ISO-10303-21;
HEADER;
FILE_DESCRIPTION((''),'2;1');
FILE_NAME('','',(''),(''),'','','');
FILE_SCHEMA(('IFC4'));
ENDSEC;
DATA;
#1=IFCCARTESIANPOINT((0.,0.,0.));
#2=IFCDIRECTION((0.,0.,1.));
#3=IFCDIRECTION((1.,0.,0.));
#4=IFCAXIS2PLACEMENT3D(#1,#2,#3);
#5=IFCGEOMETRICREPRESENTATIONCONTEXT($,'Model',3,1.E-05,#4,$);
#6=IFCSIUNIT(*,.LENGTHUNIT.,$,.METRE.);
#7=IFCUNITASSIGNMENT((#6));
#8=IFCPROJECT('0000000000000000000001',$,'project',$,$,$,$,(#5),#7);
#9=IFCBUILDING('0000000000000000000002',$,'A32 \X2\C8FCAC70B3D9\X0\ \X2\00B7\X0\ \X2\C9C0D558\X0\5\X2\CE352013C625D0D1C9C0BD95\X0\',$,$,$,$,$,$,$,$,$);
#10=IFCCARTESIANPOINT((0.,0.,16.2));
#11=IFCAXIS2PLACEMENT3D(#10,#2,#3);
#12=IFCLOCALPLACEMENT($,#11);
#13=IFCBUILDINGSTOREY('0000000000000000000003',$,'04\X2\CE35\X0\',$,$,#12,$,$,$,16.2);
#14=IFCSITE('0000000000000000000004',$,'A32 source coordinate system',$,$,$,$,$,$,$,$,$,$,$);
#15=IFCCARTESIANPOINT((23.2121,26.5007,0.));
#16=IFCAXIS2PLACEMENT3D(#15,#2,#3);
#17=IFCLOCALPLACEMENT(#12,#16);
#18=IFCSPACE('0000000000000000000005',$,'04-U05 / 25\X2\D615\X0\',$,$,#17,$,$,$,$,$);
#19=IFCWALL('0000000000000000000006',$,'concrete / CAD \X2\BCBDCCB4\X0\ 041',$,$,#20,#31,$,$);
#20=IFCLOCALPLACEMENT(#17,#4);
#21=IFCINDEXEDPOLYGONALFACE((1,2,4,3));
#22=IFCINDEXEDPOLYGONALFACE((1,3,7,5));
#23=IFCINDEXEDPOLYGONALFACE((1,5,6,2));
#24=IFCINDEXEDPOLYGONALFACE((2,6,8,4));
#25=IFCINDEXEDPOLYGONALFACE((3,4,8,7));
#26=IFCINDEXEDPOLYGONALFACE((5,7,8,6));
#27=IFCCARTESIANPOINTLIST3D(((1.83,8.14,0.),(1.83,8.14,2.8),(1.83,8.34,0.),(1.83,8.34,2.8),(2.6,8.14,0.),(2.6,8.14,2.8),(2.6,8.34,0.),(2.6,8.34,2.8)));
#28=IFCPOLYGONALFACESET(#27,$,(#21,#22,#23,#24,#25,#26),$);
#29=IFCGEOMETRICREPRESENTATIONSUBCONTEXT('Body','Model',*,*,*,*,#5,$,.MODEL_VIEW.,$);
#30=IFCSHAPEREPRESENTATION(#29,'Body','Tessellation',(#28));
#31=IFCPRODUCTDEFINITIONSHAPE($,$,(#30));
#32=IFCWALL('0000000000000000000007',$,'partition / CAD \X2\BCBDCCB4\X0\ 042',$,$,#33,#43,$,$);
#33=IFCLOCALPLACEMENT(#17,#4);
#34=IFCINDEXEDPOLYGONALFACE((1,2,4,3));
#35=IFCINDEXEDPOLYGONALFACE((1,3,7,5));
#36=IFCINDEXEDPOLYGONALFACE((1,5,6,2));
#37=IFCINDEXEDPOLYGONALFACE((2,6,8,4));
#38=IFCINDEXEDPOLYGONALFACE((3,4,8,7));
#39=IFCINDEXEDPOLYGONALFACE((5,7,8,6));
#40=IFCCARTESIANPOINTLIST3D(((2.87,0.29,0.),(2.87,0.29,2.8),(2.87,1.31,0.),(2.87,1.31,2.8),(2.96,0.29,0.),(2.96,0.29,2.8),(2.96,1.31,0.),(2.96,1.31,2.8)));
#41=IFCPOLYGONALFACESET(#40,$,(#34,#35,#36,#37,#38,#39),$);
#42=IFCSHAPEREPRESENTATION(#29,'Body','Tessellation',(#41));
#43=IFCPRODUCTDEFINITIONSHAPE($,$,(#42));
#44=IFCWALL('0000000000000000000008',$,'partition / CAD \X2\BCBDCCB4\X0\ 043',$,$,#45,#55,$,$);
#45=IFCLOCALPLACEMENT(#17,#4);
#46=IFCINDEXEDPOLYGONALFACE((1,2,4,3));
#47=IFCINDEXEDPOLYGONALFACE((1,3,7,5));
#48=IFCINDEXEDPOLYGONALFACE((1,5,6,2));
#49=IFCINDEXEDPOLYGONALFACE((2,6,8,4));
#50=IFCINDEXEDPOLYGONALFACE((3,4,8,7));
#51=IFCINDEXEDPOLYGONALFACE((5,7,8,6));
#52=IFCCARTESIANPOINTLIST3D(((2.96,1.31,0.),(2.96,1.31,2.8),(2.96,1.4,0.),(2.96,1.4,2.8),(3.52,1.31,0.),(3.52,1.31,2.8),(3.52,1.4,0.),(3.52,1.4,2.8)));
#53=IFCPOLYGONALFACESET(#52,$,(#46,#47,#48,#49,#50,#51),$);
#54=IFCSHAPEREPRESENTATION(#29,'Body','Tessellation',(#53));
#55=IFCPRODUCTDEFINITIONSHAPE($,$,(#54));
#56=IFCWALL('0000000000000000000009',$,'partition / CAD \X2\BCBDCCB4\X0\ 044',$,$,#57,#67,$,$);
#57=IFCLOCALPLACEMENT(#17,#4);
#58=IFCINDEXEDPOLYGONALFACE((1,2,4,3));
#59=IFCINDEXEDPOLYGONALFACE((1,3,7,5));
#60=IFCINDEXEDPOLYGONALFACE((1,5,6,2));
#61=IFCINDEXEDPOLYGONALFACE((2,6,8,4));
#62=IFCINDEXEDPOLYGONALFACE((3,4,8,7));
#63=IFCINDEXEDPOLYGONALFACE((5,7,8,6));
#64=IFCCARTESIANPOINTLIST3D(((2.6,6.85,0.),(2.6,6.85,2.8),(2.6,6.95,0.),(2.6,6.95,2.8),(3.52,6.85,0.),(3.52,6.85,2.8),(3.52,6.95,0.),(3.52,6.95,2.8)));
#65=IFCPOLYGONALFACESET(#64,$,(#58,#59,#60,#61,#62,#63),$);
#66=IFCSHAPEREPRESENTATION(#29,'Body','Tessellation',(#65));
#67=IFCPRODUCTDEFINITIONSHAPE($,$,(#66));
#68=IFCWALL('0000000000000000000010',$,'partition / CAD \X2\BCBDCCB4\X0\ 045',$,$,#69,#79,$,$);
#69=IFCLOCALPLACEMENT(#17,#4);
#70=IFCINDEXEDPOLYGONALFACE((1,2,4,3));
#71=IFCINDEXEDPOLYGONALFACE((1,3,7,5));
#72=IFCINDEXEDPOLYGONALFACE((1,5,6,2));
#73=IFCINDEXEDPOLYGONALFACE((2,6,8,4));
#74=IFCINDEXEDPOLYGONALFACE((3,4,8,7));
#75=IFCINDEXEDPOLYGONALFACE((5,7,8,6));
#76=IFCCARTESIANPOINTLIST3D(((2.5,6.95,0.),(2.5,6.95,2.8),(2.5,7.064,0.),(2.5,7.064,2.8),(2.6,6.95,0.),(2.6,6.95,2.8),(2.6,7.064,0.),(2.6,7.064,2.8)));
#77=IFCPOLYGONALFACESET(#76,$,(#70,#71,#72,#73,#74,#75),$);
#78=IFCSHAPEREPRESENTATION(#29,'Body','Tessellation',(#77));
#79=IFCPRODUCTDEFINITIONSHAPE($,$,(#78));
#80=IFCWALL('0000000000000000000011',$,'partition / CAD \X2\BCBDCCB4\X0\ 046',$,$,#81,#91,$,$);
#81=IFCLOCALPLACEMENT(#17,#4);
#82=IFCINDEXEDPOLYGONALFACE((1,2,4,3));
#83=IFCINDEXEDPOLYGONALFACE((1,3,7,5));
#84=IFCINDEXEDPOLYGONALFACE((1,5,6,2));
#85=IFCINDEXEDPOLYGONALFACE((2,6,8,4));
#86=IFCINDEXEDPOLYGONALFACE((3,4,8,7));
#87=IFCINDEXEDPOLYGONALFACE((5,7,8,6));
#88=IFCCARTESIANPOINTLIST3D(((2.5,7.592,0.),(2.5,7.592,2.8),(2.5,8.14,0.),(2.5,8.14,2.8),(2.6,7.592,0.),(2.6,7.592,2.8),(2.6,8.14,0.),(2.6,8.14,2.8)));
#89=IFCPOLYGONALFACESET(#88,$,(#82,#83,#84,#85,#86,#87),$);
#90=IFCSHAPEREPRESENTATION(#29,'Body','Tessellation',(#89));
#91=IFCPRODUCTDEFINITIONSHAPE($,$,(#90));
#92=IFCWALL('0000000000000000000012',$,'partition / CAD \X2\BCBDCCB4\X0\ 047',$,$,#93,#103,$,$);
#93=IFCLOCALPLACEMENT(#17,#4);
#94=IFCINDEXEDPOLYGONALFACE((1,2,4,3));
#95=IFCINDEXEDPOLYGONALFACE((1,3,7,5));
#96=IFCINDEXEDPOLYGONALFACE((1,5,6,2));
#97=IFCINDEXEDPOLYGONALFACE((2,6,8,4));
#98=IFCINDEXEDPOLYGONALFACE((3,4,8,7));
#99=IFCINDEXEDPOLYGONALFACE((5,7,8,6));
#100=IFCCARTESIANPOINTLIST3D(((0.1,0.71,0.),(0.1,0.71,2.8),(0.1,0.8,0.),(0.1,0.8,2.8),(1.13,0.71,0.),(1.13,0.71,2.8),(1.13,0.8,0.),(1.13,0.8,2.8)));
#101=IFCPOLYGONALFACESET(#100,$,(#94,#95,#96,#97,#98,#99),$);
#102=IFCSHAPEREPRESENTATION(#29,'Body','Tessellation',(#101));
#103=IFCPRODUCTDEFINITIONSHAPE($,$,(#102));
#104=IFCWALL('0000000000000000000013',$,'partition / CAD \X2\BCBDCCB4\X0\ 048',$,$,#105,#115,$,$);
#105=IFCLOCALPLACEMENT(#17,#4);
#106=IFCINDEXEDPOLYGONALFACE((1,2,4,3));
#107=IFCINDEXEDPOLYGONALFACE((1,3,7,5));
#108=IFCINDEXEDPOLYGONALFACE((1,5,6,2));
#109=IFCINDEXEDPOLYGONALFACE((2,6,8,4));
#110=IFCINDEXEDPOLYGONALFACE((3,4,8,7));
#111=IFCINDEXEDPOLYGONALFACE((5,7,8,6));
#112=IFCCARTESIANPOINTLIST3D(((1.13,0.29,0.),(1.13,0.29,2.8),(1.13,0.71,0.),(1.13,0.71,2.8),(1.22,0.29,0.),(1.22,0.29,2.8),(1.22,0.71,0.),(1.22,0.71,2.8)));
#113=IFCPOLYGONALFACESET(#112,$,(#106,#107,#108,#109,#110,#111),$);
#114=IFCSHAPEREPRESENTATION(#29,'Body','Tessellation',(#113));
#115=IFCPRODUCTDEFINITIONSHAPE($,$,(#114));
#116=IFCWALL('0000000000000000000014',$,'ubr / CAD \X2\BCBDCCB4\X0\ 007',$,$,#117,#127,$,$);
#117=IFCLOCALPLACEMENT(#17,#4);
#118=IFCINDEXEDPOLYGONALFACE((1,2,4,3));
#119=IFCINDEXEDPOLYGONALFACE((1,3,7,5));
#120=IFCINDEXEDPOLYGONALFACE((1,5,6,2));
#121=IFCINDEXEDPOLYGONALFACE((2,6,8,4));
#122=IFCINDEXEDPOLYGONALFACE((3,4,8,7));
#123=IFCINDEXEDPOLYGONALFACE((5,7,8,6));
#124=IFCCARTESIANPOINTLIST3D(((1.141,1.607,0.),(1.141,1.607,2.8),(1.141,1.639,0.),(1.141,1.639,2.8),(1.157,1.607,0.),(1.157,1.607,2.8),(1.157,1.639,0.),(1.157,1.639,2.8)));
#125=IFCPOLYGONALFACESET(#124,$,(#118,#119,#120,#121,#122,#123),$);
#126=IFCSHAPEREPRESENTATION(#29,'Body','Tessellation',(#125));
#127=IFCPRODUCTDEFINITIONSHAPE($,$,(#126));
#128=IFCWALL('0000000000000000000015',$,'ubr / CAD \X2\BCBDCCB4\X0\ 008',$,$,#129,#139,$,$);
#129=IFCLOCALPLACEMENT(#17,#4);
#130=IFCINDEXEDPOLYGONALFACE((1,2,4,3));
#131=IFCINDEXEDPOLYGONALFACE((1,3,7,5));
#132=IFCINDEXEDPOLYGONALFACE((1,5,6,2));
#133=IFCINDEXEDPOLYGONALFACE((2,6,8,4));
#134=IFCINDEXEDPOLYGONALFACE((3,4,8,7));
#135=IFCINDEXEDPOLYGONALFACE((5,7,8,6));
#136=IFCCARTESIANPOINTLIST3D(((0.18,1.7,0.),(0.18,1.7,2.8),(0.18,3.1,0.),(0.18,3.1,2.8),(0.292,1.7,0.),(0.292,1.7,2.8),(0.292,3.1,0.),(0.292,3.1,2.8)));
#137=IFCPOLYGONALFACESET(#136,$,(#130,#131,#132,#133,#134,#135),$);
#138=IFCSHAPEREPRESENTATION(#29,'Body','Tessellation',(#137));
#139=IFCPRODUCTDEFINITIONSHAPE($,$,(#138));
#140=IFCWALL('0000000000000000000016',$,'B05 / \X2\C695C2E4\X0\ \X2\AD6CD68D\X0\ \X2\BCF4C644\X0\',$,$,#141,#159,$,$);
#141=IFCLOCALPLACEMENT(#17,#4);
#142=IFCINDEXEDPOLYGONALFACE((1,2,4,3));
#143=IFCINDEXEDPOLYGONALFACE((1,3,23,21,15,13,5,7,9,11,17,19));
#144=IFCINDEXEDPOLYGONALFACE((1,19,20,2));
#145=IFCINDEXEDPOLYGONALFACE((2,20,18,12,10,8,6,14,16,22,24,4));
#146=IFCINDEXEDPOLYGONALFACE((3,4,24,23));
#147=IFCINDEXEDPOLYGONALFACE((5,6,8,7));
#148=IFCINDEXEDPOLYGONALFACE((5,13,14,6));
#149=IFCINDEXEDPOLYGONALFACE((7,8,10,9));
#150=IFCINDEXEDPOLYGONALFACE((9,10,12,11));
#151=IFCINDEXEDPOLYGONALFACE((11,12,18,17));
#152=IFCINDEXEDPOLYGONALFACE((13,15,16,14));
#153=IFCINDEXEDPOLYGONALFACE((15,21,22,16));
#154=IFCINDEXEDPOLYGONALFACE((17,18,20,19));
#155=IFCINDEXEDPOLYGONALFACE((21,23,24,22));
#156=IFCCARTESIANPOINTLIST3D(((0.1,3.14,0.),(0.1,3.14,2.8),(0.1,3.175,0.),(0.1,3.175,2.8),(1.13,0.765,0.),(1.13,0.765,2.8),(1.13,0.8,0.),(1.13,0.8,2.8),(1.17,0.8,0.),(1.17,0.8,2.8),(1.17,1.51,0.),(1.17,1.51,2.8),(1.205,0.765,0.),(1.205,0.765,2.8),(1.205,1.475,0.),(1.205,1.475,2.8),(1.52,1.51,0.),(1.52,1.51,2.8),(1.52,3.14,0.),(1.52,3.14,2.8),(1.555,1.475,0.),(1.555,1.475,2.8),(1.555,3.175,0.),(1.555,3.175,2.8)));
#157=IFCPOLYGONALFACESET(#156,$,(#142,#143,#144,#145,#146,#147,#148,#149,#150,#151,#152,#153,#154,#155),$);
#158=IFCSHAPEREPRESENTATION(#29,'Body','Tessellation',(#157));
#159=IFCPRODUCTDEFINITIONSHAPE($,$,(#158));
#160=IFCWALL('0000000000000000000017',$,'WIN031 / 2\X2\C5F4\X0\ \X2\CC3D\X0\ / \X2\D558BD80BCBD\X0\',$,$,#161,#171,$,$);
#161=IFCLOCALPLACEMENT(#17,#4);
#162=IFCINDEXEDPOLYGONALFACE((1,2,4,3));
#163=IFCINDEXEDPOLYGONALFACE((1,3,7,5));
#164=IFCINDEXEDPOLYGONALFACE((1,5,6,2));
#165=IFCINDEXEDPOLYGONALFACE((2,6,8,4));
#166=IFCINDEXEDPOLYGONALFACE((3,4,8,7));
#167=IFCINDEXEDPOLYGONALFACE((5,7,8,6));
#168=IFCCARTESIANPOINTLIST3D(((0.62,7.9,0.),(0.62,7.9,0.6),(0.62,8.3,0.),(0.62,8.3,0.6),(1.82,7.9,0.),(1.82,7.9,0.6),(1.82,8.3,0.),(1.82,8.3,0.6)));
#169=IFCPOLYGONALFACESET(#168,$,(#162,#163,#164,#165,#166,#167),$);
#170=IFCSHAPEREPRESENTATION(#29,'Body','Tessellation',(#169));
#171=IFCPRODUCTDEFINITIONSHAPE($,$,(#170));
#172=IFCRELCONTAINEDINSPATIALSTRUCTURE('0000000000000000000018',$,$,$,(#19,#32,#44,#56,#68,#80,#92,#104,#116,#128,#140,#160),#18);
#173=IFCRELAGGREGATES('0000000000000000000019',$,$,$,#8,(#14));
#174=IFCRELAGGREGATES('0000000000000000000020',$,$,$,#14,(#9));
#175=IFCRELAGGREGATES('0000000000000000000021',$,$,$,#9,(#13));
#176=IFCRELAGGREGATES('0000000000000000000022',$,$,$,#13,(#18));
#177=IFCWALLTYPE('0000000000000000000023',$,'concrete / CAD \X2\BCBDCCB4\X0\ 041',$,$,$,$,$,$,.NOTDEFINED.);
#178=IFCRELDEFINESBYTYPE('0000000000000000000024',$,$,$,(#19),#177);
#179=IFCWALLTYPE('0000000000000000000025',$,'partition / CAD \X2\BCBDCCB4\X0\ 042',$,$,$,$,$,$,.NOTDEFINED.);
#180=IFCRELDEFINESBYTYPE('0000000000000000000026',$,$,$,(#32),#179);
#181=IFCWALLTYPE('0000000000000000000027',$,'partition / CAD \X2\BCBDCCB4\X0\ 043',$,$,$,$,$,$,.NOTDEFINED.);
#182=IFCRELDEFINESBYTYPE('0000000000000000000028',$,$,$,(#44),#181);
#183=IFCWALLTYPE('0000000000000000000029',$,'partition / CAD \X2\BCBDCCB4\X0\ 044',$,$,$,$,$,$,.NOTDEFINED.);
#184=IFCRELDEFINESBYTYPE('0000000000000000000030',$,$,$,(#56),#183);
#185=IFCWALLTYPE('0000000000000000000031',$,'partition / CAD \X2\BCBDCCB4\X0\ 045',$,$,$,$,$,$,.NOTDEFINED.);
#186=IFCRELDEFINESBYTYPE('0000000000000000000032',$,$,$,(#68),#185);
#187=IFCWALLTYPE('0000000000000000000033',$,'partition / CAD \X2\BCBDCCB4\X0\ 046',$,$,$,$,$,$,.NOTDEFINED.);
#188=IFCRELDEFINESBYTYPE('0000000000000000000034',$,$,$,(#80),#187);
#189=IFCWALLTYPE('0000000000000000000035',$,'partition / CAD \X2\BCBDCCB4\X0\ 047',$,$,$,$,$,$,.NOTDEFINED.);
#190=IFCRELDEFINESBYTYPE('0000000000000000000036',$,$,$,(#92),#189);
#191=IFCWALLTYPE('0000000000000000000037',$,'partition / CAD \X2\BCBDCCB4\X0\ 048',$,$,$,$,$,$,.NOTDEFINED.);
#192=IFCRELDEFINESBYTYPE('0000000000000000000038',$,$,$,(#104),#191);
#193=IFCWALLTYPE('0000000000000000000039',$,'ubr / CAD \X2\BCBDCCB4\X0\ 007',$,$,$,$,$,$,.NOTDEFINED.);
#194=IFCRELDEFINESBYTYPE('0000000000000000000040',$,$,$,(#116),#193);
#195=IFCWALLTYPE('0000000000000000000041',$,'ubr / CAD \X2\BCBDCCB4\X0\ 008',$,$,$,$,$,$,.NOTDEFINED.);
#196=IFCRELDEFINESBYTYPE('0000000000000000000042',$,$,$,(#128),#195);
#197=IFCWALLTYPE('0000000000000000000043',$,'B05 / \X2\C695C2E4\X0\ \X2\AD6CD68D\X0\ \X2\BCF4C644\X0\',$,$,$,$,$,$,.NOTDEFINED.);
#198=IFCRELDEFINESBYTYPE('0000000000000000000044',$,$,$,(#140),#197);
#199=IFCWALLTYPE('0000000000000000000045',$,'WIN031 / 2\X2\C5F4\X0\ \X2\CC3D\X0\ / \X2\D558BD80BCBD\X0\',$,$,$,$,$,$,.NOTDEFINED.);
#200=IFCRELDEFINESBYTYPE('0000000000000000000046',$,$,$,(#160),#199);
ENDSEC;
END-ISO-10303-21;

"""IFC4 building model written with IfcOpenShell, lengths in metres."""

from ifc_helpers import new_model, si_unit, frame, origin, origin_with_axes, place, context, subcontext, project, spatial, polyline, outline, extrude, source, transform, mapped, type_object, type_shapes, element, save


model = new_model("IFC4")

# Units and contexts
model_context = context("Model", 3, precision=1e-05, world=origin_with_axes())
body_context = subcontext(model_context, "Body", "Model", "MODEL_VIEW")
ifc_project = project(units=[si_unit("LENGTHUNIT", "METRE")], contexts=[model_context])

# Site, building, storey, space
site = spatial("IfcSite", under=ifc_project, Name="A32 source coordinate system")
building = spatial("IfcBuilding", under=site, Name="A32 주거동 · 지하5층–옥탑지붕")
storey_placement = place(None, frame((0.0, 0.0, 16.2), z_axis=(0.0, 0.0, 1.0), x_axis=(1.0, 0.0, 0.0)))
storey = spatial("IfcBuildingStorey", under=building, at=storey_placement, Name="04층", Elevation=16.2)
space_1_placement = place(storey_placement, frame((23.2121, 26.5007, 0.0), z_axis=(0.0, 0.0, 1.0), x_axis=(1.0, 0.0, 0.0)))
space_1 = spatial("IfcSpace", under=storey, at=space_1_placement, Name="04-U05 / 25형")

# Walls
wall_type_1 = type_object("IfcWallType", Name="concrete / CAD 벽체 041", PredefinedType="NOTDEFINED")
shared_shape_1 = source(origin(), body_context, "Body", "SweptSolid", [
    extrude(outline(polyline([(2.6, 8.14), (1.83, 8.14), (1.83, 8.34), (2.6, 8.34), (2.6, 8.14)])), origin(), (0.0, 0.0, 1.0), 2.8),
])
type_shapes(wall_type_1, [shared_shape_1])
wall_1_placement = place(space_1_placement, origin_with_axes())
element("IfcWall", 1, at=wall_1_placement, inside=space_1, type_object=wall_type_1, Name="concrete / CAD 벽체 041", context=body_context, shape_type="MappedRepresentation", body=[
    mapped(shared_shape_1, transform((0.0, 0.0, 0.0), scale=1.0)),
])
wall_type_2 = type_object("IfcWallType", Name="partition / CAD 벽체 042", PredefinedType="NOTDEFINED")
shared_shape_2 = source(origin(), body_context, "Body", "SweptSolid", [
    extrude(outline(polyline([(2.87, 1.31), (2.96, 1.31), (2.96, 0.29), (2.87, 0.29), (2.87, 1.31)])), origin(), (0.0, 0.0, 1.0), 2.8),
])
type_shapes(wall_type_2, [shared_shape_2])
wall_2_placement = place(space_1_placement, origin_with_axes())
element("IfcWall", 2, at=wall_2_placement, inside=space_1, type_object=wall_type_2, Name="partition / CAD 벽체 042", context=body_context, shape_type="MappedRepresentation", body=[
    mapped(shared_shape_2, transform((0.0, 0.0, 0.0), scale=1.0)),
])
wall_type_3 = type_object("IfcWallType", Name="partition / CAD 벽체 043", PredefinedType="NOTDEFINED")
shared_shape_3 = source(origin(), body_context, "Body", "SweptSolid", [
    extrude(outline(polyline([(3.52, 1.4), (3.52, 1.31), (2.96, 1.31), (2.96, 1.4), (3.52, 1.4)])), origin(), (0.0, 0.0, 1.0), 2.8),
])
type_shapes(wall_type_3, [shared_shape_3])
wall_3_placement = place(space_1_placement, origin_with_axes())
element("IfcWall", 3, at=wall_3_placement, inside=space_1, type_object=wall_type_3, Name="partition / CAD 벽체 043", context=body_context, shape_type="MappedRepresentation", body=[
    mapped(shared_shape_3, transform((0.0, 0.0, 0.0), scale=1.0)),
])
wall_type_4 = type_object("IfcWallType", Name="partition / CAD 벽체 044", PredefinedType="NOTDEFINED")
shared_shape_4 = source(origin(), body_context, "Body", "SweptSolid", [
    extrude(outline(polyline([(3.52, 6.95), (3.52, 6.85), (2.6, 6.85), (2.6, 6.95), (3.52, 6.95)])), origin(), (0.0, 0.0, 1.0), 2.8),
])
type_shapes(wall_type_4, [shared_shape_4])
wall_4_placement = place(space_1_placement, origin_with_axes())
element("IfcWall", 4, at=wall_4_placement, inside=space_1, type_object=wall_type_4, Name="partition / CAD 벽체 044", context=body_context, shape_type="MappedRepresentation", body=[
    mapped(shared_shape_4, transform((0.0, 0.0, 0.0), scale=1.0)),
])
wall_type_5 = type_object("IfcWallType", Name="partition / CAD 벽체 045", PredefinedType="NOTDEFINED")
shared_shape_5 = source(origin(), body_context, "Body", "SweptSolid", [
    extrude(outline(polyline([(2.5, 7.064), (2.6, 7.064), (2.6, 6.95), (2.5, 6.95), (2.5, 7.064)])), origin(), (0.0, 0.0, 1.0), 2.8),
])
type_shapes(wall_type_5, [shared_shape_5])
wall_5_placement = place(space_1_placement, origin_with_axes())
element("IfcWall", 5, at=wall_5_placement, inside=space_1, type_object=wall_type_5, Name="partition / CAD 벽체 045", context=body_context, shape_type="MappedRepresentation", body=[
    mapped(shared_shape_5, transform((0.0, 0.0, 0.0), scale=1.0)),
])
wall_type_6 = type_object("IfcWallType", Name="partition / CAD 벽체 046", PredefinedType="NOTDEFINED")
shared_shape_6 = source(origin(), body_context, "Body", "SweptSolid", [
    extrude(outline(polyline([(2.6, 7.592), (2.5, 7.592), (2.5, 8.14), (2.6, 8.14), (2.6, 7.592)])), origin(), (0.0, 0.0, 1.0), 2.8),
])
type_shapes(wall_type_6, [shared_shape_6])
wall_6_placement = place(space_1_placement, origin_with_axes())
element("IfcWall", 6, at=wall_6_placement, inside=space_1, type_object=wall_type_6, Name="partition / CAD 벽체 046", context=body_context, shape_type="MappedRepresentation", body=[
    mapped(shared_shape_6, transform((0.0, 0.0, 0.0), scale=1.0)),
])
wall_type_7 = type_object("IfcWallType", Name="partition / CAD 벽체 047", PredefinedType="NOTDEFINED")
shared_shape_7 = source(origin(), body_context, "Body", "SweptSolid", [
    extrude(outline(polyline([(1.13, 0.71), (0.1, 0.71), (0.1, 0.8), (1.13, 0.8), (1.13, 0.71)])), origin(), (0.0, 0.0, 1.0), 2.8),
])
type_shapes(wall_type_7, [shared_shape_7])
wall_7_placement = place(space_1_placement, origin_with_axes())
element("IfcWall", 7, at=wall_7_placement, inside=space_1, type_object=wall_type_7, Name="partition / CAD 벽체 047", context=body_context, shape_type="MappedRepresentation", body=[
    mapped(shared_shape_7, transform((0.0, 0.0, 0.0), scale=1.0)),
])
wall_type_8 = type_object("IfcWallType", Name="partition / CAD 벽체 048", PredefinedType="NOTDEFINED")
shared_shape_8 = source(origin(), body_context, "Body", "SweptSolid", [
    extrude(outline(polyline([(1.22, 0.29), (1.13, 0.29), (1.13, 0.71), (1.22, 0.71), (1.22, 0.29)])), origin(), (0.0, 0.0, 1.0), 2.8),
])
type_shapes(wall_type_8, [shared_shape_8])
wall_8_placement = place(space_1_placement, origin_with_axes())
element("IfcWall", 8, at=wall_8_placement, inside=space_1, type_object=wall_type_8, Name="partition / CAD 벽체 048", context=body_context, shape_type="MappedRepresentation", body=[
    mapped(shared_shape_8, transform((0.0, 0.0, 0.0), scale=1.0)),
])
wall_type_9 = type_object("IfcWallType", Name="ubr / CAD 벽체 007", PredefinedType="NOTDEFINED")
shared_shape_9 = source(origin(), body_context, "Body", "SweptSolid", [
    extrude(outline(polyline([(1.157, 1.607), (1.141, 1.607), (1.141, 1.639), (1.157, 1.639), (1.157, 1.607)])), origin(), (0.0, 0.0, 1.0), 2.8),
])
type_shapes(wall_type_9, [shared_shape_9])
wall_9_placement = place(space_1_placement, origin_with_axes())
element("IfcWall", 9, at=wall_9_placement, inside=space_1, type_object=wall_type_9, Name="ubr / CAD 벽체 007", context=body_context, shape_type="MappedRepresentation", body=[
    mapped(shared_shape_9, transform((0.0, 0.0, 0.0), scale=1.0)),
])
wall_type_10 = type_object("IfcWallType", Name="ubr / CAD 벽체 008", PredefinedType="NOTDEFINED")
shared_shape_10 = source(origin(), body_context, "Body", "SweptSolid", [
    extrude(outline(polyline([(0.292, 1.7), (0.18, 1.7), (0.18, 3.1), (0.292, 3.1), (0.292, 1.7)])), origin(), (0.0, 0.0, 1.0), 2.8),
])
type_shapes(wall_type_10, [shared_shape_10])
wall_10_placement = place(space_1_placement, origin_with_axes())
element("IfcWall", 10, at=wall_10_placement, inside=space_1, type_object=wall_type_10, Name="ubr / CAD 벽체 008", context=body_context, shape_type="MappedRepresentation", body=[
    mapped(shared_shape_10, transform((0.0, 0.0, 0.0), scale=1.0)),
])
wall_type_11 = type_object("IfcWallType", Name="B05 / 욕실 구획 보완", PredefinedType="NOTDEFINED")
shared_shape_11 = source(origin(), body_context, "Body", "SweptSolid", [
    extrude(outline(polyline([(1.17, 1.51), (1.52, 1.51), (1.52, 3.14), (0.1, 3.14), (0.1, 3.175), (1.555, 3.175), (1.555, 1.475), (1.205, 1.475), (1.205, 0.765), (1.13, 0.765), (1.13, 0.8), (1.17, 0.8), (1.17, 1.51)])), origin(), (0.0, 0.0, 1.0), 2.8),
])
type_shapes(wall_type_11, [shared_shape_11])
wall_11_placement = place(space_1_placement, origin_with_axes())
element("IfcWall", 11, at=wall_11_placement, inside=space_1, type_object=wall_type_11, Name="B05 / 욕실 구획 보완", context=body_context, shape_type="MappedRepresentation", body=[
    mapped(shared_shape_11, transform((0.0, 0.0, 0.0), scale=1.0)),
])
wall_type_12 = type_object("IfcWallType", Name="WIN031 / 2열 창 / 하부벽", PredefinedType="NOTDEFINED")
shared_shape_12 = source(origin(), body_context, "Body", "SweptSolid", [
    extrude(outline(polyline([(0.62, 8.3), (1.82, 8.3), (1.82, 7.9), (0.62, 7.9), (0.62, 8.3)])), origin(), (0.0, 0.0, 1.0), 0.6),
])
type_shapes(wall_type_12, [shared_shape_12])
wall_12_placement = place(space_1_placement, origin_with_axes())
element("IfcWall", 12, at=wall_12_placement, inside=space_1, type_object=wall_type_12, Name="WIN031 / 2열 창 / 하부벽", context=body_context, shape_type="MappedRepresentation", body=[
    mapped(shared_shape_12, transform((0.0, 0.0, 0.0), scale=1.0)),
])

save(model, "model.ifc")
